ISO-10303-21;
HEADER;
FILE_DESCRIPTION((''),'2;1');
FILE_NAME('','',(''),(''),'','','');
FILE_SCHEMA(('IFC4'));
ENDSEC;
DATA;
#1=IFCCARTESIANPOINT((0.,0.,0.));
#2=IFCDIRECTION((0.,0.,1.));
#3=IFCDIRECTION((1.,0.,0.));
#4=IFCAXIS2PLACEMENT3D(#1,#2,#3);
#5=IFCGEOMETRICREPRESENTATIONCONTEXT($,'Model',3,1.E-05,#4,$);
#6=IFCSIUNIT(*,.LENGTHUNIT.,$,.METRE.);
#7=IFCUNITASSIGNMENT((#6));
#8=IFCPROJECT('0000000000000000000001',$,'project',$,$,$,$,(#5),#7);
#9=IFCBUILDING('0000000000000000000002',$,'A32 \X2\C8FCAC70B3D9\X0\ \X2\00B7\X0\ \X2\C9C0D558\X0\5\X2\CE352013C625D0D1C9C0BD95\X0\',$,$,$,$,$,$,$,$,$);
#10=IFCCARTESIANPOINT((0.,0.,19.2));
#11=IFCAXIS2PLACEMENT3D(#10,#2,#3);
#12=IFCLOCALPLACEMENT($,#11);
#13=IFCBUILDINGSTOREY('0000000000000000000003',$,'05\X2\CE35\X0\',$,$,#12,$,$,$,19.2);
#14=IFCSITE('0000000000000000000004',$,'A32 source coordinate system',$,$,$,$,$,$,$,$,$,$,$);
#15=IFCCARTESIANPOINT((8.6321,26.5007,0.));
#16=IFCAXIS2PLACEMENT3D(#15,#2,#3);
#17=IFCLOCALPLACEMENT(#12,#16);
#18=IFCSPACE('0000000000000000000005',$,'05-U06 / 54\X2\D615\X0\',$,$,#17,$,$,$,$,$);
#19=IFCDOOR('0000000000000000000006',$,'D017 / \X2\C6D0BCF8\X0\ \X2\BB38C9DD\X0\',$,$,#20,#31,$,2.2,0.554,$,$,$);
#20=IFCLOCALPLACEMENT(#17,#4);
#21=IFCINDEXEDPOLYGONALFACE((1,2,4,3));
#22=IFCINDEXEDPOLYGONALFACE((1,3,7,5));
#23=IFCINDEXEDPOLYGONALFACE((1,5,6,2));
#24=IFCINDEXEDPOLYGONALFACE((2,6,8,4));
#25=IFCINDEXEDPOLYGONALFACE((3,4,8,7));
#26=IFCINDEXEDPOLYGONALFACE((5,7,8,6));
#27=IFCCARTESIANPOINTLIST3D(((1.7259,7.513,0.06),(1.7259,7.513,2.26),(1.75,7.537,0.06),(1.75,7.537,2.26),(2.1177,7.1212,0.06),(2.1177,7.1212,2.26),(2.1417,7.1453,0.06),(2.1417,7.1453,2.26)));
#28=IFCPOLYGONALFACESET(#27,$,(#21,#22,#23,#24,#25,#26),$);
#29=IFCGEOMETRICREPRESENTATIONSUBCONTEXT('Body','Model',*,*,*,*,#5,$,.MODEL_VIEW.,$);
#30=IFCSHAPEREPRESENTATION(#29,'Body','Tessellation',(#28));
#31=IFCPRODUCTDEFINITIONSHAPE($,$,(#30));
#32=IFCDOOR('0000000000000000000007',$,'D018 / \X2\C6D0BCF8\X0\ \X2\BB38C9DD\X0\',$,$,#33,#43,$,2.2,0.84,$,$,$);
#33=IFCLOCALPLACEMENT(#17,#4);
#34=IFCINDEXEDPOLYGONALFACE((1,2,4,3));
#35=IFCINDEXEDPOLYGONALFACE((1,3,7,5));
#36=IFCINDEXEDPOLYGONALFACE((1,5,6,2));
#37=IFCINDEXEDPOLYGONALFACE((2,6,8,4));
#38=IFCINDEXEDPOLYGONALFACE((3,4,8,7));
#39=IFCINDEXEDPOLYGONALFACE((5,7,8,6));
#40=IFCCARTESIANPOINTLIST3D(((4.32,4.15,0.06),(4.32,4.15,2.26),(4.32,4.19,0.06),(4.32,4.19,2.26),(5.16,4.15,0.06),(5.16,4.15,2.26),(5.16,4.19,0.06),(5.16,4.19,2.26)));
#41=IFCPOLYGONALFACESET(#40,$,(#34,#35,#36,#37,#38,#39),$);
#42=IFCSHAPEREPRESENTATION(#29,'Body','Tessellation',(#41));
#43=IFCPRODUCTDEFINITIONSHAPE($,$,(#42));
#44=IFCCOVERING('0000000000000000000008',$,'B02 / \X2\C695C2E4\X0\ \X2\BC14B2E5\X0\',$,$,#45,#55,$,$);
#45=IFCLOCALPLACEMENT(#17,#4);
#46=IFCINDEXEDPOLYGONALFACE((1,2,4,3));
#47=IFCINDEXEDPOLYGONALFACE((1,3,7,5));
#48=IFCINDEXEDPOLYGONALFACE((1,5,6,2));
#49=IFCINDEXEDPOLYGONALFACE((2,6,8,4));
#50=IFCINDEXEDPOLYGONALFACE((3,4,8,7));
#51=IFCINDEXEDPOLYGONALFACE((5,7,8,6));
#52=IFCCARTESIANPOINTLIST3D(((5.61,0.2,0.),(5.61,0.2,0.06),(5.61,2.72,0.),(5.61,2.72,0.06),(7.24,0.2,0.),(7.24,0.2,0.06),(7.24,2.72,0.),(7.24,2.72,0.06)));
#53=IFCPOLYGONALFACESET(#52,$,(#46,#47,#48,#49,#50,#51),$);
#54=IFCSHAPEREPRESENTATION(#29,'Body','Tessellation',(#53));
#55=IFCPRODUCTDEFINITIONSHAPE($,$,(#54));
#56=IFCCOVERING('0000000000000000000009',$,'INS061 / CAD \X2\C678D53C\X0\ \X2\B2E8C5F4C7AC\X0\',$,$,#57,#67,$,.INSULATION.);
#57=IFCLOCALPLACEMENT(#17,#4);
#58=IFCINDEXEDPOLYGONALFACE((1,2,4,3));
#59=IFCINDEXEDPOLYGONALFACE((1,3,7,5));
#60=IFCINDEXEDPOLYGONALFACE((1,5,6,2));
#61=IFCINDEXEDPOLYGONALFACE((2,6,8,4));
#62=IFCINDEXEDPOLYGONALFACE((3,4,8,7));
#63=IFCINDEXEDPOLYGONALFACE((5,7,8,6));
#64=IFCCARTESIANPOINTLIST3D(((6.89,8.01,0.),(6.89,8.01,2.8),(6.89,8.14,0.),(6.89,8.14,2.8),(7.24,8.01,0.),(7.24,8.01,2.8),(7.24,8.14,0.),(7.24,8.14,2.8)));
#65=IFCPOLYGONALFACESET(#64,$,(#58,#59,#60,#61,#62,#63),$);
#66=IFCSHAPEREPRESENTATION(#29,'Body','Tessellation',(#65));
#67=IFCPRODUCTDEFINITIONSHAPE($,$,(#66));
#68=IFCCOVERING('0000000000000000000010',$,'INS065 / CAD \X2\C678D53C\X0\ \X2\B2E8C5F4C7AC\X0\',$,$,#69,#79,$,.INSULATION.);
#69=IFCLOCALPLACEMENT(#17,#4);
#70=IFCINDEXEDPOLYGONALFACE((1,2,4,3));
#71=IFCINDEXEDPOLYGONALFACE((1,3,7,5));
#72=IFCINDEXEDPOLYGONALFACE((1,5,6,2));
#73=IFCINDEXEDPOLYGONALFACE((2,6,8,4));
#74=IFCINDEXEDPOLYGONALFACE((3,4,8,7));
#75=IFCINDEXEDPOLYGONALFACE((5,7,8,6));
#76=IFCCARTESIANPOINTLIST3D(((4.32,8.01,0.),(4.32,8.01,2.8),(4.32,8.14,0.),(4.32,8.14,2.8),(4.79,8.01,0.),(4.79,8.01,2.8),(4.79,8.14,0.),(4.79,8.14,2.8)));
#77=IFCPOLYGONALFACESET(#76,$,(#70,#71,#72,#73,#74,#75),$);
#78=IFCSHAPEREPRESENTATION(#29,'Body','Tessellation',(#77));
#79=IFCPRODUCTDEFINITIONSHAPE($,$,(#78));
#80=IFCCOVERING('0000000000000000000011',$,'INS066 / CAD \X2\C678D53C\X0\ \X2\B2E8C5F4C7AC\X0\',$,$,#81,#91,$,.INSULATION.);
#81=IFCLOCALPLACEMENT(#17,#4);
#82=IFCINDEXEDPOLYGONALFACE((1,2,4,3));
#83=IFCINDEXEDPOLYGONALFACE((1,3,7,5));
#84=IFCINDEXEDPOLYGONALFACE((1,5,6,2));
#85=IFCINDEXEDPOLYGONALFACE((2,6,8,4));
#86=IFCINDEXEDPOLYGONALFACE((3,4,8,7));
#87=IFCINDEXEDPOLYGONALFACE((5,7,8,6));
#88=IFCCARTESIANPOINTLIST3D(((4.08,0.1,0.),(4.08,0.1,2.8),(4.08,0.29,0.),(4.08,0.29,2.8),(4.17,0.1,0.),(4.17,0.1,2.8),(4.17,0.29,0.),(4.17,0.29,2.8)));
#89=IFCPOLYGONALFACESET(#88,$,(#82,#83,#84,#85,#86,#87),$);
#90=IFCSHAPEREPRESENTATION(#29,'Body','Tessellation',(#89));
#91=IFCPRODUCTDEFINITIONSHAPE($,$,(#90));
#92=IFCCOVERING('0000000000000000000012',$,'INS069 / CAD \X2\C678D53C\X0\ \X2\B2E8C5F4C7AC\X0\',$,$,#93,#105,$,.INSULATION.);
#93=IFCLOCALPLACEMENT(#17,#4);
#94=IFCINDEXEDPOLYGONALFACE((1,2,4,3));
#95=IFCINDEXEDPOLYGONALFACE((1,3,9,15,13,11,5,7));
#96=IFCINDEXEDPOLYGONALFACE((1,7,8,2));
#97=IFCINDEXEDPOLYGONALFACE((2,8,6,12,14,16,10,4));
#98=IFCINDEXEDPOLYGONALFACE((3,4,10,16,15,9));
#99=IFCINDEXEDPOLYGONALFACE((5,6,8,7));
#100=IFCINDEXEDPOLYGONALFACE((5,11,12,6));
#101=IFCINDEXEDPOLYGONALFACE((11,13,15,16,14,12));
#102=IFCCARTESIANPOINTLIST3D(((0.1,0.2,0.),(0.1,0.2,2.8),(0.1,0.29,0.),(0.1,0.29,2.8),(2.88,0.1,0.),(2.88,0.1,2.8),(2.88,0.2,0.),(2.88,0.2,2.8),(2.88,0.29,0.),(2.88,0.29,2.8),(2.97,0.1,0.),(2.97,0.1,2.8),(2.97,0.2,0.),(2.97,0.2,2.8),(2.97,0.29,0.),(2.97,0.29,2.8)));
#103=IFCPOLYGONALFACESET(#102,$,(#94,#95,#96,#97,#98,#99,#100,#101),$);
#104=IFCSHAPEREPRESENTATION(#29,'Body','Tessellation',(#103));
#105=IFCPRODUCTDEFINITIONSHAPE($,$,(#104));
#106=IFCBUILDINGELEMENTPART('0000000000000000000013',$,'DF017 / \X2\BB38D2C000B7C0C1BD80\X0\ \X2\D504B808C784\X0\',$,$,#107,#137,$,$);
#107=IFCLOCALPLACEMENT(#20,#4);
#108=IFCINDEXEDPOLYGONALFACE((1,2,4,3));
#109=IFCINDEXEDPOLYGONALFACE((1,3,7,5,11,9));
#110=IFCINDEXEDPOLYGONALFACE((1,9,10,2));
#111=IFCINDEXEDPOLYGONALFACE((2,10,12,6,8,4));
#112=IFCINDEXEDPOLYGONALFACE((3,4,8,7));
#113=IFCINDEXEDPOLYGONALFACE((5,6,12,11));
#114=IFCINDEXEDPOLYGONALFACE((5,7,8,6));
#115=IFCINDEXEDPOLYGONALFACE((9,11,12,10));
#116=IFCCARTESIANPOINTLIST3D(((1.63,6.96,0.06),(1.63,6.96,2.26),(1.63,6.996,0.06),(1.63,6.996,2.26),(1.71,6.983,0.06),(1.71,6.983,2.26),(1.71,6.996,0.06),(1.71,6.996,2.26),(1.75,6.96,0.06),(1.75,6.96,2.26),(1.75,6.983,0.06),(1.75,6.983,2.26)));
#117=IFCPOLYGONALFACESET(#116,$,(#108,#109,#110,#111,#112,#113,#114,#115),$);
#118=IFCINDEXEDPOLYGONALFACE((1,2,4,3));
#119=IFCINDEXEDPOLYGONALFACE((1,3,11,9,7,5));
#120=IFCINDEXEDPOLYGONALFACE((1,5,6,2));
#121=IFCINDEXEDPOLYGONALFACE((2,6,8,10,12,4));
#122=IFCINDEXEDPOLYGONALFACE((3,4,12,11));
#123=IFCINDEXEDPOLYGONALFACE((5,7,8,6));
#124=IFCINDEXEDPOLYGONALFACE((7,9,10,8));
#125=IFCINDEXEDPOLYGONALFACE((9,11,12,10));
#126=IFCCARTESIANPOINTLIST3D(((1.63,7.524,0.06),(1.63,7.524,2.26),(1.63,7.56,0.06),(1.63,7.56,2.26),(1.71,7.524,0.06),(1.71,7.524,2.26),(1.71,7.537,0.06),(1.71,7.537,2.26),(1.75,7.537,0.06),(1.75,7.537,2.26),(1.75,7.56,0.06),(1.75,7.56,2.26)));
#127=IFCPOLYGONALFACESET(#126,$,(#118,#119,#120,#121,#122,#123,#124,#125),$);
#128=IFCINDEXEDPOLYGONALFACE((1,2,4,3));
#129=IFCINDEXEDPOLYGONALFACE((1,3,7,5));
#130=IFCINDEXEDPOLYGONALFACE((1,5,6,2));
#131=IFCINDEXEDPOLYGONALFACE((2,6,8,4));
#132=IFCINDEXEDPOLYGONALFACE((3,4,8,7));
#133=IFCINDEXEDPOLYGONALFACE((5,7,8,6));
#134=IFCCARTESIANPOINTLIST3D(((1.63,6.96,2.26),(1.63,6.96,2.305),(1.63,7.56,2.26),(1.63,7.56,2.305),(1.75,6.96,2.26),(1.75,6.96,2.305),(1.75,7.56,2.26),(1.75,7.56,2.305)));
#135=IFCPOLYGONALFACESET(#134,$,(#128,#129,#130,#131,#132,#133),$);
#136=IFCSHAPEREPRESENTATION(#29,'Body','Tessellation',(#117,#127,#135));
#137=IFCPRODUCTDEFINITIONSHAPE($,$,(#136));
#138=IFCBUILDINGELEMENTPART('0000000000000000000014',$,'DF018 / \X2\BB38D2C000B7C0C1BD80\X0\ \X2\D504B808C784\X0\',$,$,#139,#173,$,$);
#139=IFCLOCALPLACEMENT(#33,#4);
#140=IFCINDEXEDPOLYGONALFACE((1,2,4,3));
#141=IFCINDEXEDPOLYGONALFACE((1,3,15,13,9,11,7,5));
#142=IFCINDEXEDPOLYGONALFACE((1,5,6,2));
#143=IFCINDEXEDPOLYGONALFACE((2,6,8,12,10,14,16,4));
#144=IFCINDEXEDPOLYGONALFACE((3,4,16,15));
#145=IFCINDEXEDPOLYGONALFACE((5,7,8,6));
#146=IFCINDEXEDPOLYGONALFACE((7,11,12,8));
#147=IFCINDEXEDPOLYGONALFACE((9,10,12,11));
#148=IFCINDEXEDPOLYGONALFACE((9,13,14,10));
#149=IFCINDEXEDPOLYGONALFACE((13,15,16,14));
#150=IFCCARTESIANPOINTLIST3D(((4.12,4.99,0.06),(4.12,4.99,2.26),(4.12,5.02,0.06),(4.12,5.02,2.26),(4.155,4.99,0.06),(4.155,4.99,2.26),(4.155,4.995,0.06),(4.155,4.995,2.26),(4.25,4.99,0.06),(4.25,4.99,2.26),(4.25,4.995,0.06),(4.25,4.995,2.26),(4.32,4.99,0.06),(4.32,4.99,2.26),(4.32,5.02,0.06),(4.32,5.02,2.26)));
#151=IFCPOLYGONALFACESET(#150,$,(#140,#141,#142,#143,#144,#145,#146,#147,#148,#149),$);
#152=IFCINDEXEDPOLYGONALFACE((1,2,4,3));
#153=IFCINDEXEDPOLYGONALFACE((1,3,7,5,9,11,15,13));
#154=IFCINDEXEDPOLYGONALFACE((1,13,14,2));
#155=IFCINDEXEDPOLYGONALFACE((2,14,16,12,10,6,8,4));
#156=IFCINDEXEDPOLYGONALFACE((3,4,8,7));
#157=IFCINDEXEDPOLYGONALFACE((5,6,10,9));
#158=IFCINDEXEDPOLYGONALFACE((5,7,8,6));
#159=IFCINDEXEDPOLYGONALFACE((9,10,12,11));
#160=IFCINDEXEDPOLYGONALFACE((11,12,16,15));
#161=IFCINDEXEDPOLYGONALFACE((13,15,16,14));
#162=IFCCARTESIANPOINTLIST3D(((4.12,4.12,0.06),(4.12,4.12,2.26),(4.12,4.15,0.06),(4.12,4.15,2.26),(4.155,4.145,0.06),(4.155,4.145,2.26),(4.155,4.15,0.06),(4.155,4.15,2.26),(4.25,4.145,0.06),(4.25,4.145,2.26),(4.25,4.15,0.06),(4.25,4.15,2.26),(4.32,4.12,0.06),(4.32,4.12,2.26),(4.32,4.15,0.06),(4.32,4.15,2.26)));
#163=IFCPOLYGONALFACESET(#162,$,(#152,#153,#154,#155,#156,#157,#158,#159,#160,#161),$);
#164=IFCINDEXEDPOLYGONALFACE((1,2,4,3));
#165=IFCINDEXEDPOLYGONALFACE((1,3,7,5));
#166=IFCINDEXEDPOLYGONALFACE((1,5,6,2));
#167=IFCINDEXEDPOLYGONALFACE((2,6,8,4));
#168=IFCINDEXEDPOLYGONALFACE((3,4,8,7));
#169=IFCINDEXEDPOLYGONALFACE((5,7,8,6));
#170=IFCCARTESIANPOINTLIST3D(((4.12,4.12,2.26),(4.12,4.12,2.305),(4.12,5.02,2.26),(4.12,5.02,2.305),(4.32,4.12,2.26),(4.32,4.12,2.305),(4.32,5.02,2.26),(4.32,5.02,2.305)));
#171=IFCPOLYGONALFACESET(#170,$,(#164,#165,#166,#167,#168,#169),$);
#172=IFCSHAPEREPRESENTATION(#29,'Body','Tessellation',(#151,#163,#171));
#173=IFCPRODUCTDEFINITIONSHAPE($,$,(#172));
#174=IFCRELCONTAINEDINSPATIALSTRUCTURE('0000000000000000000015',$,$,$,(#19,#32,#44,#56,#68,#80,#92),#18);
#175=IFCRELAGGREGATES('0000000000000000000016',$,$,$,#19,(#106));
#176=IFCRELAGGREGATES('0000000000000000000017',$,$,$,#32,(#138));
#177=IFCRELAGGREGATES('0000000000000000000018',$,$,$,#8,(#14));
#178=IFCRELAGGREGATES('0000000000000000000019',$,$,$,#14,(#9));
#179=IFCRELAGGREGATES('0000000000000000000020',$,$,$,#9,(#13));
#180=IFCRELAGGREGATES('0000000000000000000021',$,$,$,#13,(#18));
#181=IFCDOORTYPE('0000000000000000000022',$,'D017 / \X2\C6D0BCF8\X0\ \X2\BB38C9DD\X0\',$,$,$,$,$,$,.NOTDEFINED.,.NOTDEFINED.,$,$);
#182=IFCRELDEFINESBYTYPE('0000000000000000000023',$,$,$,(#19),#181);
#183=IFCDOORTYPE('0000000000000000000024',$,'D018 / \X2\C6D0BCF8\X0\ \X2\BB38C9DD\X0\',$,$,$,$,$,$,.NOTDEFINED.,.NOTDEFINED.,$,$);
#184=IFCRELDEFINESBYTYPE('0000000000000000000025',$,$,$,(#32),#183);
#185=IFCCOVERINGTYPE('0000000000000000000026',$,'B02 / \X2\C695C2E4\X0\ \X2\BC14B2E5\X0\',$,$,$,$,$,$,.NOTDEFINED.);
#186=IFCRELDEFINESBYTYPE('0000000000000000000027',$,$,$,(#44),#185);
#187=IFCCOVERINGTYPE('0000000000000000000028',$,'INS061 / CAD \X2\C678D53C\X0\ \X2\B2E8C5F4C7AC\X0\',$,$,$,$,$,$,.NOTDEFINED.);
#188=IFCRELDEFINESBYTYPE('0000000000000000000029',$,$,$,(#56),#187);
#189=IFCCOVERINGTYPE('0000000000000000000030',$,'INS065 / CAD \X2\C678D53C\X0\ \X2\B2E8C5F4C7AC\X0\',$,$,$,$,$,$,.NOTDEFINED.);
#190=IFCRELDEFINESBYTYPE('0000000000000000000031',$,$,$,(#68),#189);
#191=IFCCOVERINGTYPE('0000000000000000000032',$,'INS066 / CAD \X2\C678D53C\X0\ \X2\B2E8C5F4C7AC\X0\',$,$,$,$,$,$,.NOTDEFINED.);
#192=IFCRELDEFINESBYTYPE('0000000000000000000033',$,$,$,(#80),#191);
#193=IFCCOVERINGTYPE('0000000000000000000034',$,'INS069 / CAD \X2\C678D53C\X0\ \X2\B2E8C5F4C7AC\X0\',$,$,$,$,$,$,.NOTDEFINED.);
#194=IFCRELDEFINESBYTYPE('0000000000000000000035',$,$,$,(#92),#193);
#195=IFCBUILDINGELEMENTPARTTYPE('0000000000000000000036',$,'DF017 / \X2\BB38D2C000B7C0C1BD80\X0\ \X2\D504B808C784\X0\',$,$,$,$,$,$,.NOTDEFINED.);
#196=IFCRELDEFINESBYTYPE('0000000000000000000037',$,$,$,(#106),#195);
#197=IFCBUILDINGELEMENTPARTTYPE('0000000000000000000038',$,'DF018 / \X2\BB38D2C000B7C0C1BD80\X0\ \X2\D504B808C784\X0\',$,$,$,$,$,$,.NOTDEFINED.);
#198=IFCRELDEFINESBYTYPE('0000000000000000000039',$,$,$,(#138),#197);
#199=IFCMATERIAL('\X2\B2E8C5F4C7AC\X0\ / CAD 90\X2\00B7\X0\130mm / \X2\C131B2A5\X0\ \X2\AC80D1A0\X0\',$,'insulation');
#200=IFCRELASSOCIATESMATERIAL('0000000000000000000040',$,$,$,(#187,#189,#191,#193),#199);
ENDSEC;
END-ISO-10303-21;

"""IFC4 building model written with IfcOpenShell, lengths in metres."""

from ifc_helpers import new_model, si_unit, frame, origin, origin_with_axes, place, context, subcontext, project, spatial, polyline, outline, extrude, source, transform, mapped, material, type_object, type_shapes, element, aggregate, save


model = new_model("IFC4")

# Units and contexts
model_context = context("Model", 3, precision=1e-05, world=origin_with_axes())
body_context = subcontext(model_context, "Body", "Model", "MODEL_VIEW")
ifc_project = project(units=[si_unit("LENGTHUNIT", "METRE")], contexts=[model_context])

# Site, building, storey, space
storey_placement = place(None, frame((0.0, 0.0, 19.2), z_axis=(0.0, 0.0, 1.0), x_axis=(1.0, 0.0, 0.0)))
space_1_placement = place(storey_placement, frame((8.6321, 26.5007, 0.0), z_axis=(0.0, 0.0, 1.0), x_axis=(1.0, 0.0, 0.0)))
site = spatial("IfcSite", under=ifc_project, Name="A32 source coordinate system")
building = spatial("IfcBuilding", under=site, Name="A32 주거동 · 지하5층–옥탑지붕")
storey = spatial("IfcBuildingStorey", under=building, at=storey_placement, Name="05층", Elevation=19.2)
space_1 = spatial("IfcSpace", under=storey, at=space_1_placement, Name="05-U06 / 54형")

# Doors
door_type_1 = type_object("IfcDoorType", Name="D017 / 원본 문짝", OperationType="NOTDEFINED", PredefinedType="NOTDEFINED")
shared_shape_1 = source(origin(), body_context, "Body", "SweptSolid", [
    extrude(outline(polyline([(1.75, 7.537), (2.1417, 7.1453), (2.1177, 7.1212), (1.7259, 7.513), (1.75, 7.537)])), frame((0.0, 0.0, 0.06)), (0.0, 0.0, 1.0), 2.2),
])
type_shapes(door_type_1, [shared_shape_1])
door_1_placement = place(space_1_placement, origin_with_axes())
door_1 = element("IfcDoor", 1, at=door_1_placement, inside=space_1, type_object=door_type_1, Name="D017 / 원본 문짝", OverallHeight=2.2, OverallWidth=0.554, context=body_context, shape_type="MappedRepresentation", body=[
    mapped(shared_shape_1, transform((0.0, 0.0, 0.0), scale=1.0)),
])
door_type_2 = type_object("IfcDoorType", Name="D018 / 원본 문짝", OperationType="NOTDEFINED", PredefinedType="NOTDEFINED")
shared_shape_2 = source(origin(), body_context, "Body", "SweptSolid", [
    extrude(outline(polyline([(5.16, 4.19), (5.16, 4.15), (4.32, 4.15), (4.32, 4.19), (5.16, 4.19)])), frame((0.0, 0.0, 0.06)), (0.0, 0.0, 1.0), 2.2),
])
type_shapes(door_type_2, [shared_shape_2])
door_2_placement = place(space_1_placement, origin_with_axes())
door_2 = element("IfcDoor", 2, at=door_2_placement, inside=space_1, type_object=door_type_2, Name="D018 / 원본 문짝", OverallHeight=2.2, OverallWidth=0.84, context=body_context, shape_type="MappedRepresentation", body=[
    mapped(shared_shape_2, transform((0.0, 0.0, 0.0), scale=1.0)),
])

# Coverings
covering_type_1 = type_object("IfcCoveringType", Name="B02 / 욕실 바닥", PredefinedType="NOTDEFINED")
shared_shape_3 = source(origin(), body_context, "Body", "SweptSolid", [
    extrude(outline(polyline([(5.61, 2.72), (7.24, 2.72), (7.24, 0.2), (5.61, 0.2), (5.61, 2.72)])), origin(), (0.0, 0.0, 1.0), 0.06),
])
type_shapes(covering_type_1, [shared_shape_3])
covering_1_placement = place(space_1_placement, origin_with_axes())
element("IfcCovering", 3, at=covering_1_placement, inside=space_1, type_object=covering_type_1, Name="B02 / 욕실 바닥", context=body_context, shape_type="MappedRepresentation", body=[
    mapped(shared_shape_3, transform((0.0, 0.0, 0.0), scale=1.0)),
])
ifc_material = material(Name="단열재 / CAD 90·130mm / 성능 검토", Category="insulation")
covering_type_2 = type_object("IfcCoveringType", Name="INS061 / CAD 외피 단열재", PredefinedType="NOTDEFINED", material=ifc_material)
shared_shape_4 = source(origin(), body_context, "Body", "SweptSolid", [
    extrude(outline(polyline([(6.89, 8.01), (6.89, 8.14), (7.24, 8.14), (7.24, 8.01), (6.89, 8.01)])), origin(), (0.0, 0.0, 1.0), 2.8),
])
type_shapes(covering_type_2, [shared_shape_4])
covering_2_placement = place(space_1_placement, origin_with_axes())
element("IfcCovering", 4, at=covering_2_placement, inside=space_1, type_object=covering_type_2, Name="INS061 / CAD 외피 단열재", PredefinedType="INSULATION", context=body_context, shape_type="MappedRepresentation", body=[
    mapped(shared_shape_4, transform((0.0, 0.0, 0.0), scale=1.0)),
])
covering_type_3 = type_object("IfcCoveringType", Name="INS065 / CAD 외피 단열재", PredefinedType="NOTDEFINED", material=ifc_material)
shared_shape_5 = source(origin(), body_context, "Body", "SweptSolid", [
    extrude(outline(polyline([(4.32, 8.01), (4.32, 8.14), (4.79, 8.14), (4.79, 8.01), (4.32, 8.01)])), origin(), (0.0, 0.0, 1.0), 2.8),
])
type_shapes(covering_type_3, [shared_shape_5])
covering_3_placement = place(space_1_placement, origin_with_axes())
element("IfcCovering", 5, at=covering_3_placement, inside=space_1, type_object=covering_type_3, Name="INS065 / CAD 외피 단열재", PredefinedType="INSULATION", context=body_context, shape_type="MappedRepresentation", body=[
    mapped(shared_shape_5, transform((0.0, 0.0, 0.0), scale=1.0)),
])
covering_type_4 = type_object("IfcCoveringType", Name="INS066 / CAD 외피 단열재", PredefinedType="NOTDEFINED", material=ifc_material)
shared_shape_6 = source(origin(), body_context, "Body", "SweptSolid", [
    extrude(outline(polyline([(4.08, 0.29), (4.17, 0.29), (4.17, 0.1), (4.08, 0.1), (4.08, 0.29)])), origin(), (0.0, 0.0, 1.0), 2.8),
])
type_shapes(covering_type_4, [shared_shape_6])
covering_4_placement = place(space_1_placement, origin_with_axes())
element("IfcCovering", 6, at=covering_4_placement, inside=space_1, type_object=covering_type_4, Name="INS066 / CAD 외피 단열재", PredefinedType="INSULATION", context=body_context, shape_type="MappedRepresentation", body=[
    mapped(shared_shape_6, transform((0.0, 0.0, 0.0), scale=1.0)),
])
covering_type_5 = type_object("IfcCoveringType", Name="INS069 / CAD 외피 단열재", PredefinedType="NOTDEFINED", material=ifc_material)
shared_shape_7 = source(origin(), body_context, "Body", "SweptSolid", [
    extrude(outline(polyline([(2.97, 0.1), (2.88, 0.1), (2.88, 0.2), (0.1, 0.2), (0.1, 0.29), (2.88, 0.29), (2.97, 0.29), (2.97, 0.2), (2.97, 0.1)])), origin(), (0.0, 0.0, 1.0), 2.8),
])
type_shapes(covering_type_5, [shared_shape_7])
covering_5_placement = place(space_1_placement, origin_with_axes())
element("IfcCovering", 7, at=covering_5_placement, inside=space_1, type_object=covering_type_5, Name="INS069 / CAD 외피 단열재", PredefinedType="INSULATION", context=body_context, shape_type="MappedRepresentation", body=[
    mapped(shared_shape_7, transform((0.0, 0.0, 0.0), scale=1.0)),
])

# Building element parts
building_element_part_type_1 = type_object("IfcBuildingElementPartType", Name="DF017 / 문틀·상부 프레임", PredefinedType="NOTDEFINED")
shared_shape_8 = source(origin(), body_context, "Body", "SweptSolid", [
    extrude(outline(polyline([(1.63, 6.996), (1.71, 6.996), (1.71, 6.983), (1.75, 6.983), (1.75, 6.96), (1.63, 6.96), (1.63, 6.996)])), frame((0.0, 0.0, 0.06)), (0.0, 0.0, 1.0), 2.2),
    extrude(outline(polyline([(1.75, 7.56), (1.75, 7.537), (1.71, 7.537), (1.71, 7.524), (1.63, 7.524), (1.63, 7.56), (1.75, 7.56)])), frame((0.0, 0.0, 0.06)), (0.0, 0.0, 1.0), 2.2),
    extrude(outline(polyline([(1.63, 6.96), (1.63, 7.56), (1.75, 7.56), (1.75, 6.96), (1.63, 6.96)])), frame((0.0, 0.0, 2.26)), (0.0, 0.0, 1.0), 0.045),
])
type_shapes(building_element_part_type_1, [shared_shape_8])
building_element_part_1_placement = place(door_1_placement, origin_with_axes())
building_element_part_1 = element("IfcBuildingElementPart", 8, at=building_element_part_1_placement, type_object=building_element_part_type_1, Name="DF017 / 문틀·상부 프레임", context=body_context, shape_type="MappedRepresentation", body=[
    mapped(shared_shape_8, transform((0.0, 0.0, 0.0), scale=1.0)),
])
aggregate(door_1, [building_element_part_1])
building_element_part_type_2 = type_object("IfcBuildingElementPartType", Name="DF018 / 문틀·상부 프레임", PredefinedType="NOTDEFINED")
shared_shape_9 = source(origin(), body_context, "Body", "SweptSolid", [
    extrude(outline(polyline([(4.32, 4.99), (4.25, 4.99), (4.25, 4.995), (4.155, 4.995), (4.155, 4.99), (4.12, 4.99), (4.12, 5.02), (4.32, 5.02), (4.32, 4.99)])), frame((0.0, 0.0, 0.06)), (0.0, 0.0, 1.0), 2.2),
    extrude(outline(polyline([(4.12, 4.12), (4.12, 4.15), (4.155, 4.15), (4.155, 4.145), (4.25, 4.145), (4.25, 4.15), (4.32, 4.15), (4.32, 4.12), (4.12, 4.12)])), frame((0.0, 0.0, 0.06)), (0.0, 0.0, 1.0), 2.2),
    extrude(outline(polyline([(4.12, 4.12), (4.12, 5.02), (4.32, 5.02), (4.32, 4.12), (4.12, 4.12)])), frame((0.0, 0.0, 2.26)), (0.0, 0.0, 1.0), 0.045),
])
type_shapes(building_element_part_type_2, [shared_shape_9])
building_element_part_2_placement = place(door_2_placement, origin_with_axes())
building_element_part_2 = element("IfcBuildingElementPart", 9, at=building_element_part_2_placement, type_object=building_element_part_type_2, Name="DF018 / 문틀·상부 프레임", context=body_context, shape_type="MappedRepresentation", body=[
    mapped(shared_shape_9, transform((0.0, 0.0, 0.0), scale=1.0)),
])
aggregate(door_2, [building_element_part_2])

save(model, "model.ifc")
